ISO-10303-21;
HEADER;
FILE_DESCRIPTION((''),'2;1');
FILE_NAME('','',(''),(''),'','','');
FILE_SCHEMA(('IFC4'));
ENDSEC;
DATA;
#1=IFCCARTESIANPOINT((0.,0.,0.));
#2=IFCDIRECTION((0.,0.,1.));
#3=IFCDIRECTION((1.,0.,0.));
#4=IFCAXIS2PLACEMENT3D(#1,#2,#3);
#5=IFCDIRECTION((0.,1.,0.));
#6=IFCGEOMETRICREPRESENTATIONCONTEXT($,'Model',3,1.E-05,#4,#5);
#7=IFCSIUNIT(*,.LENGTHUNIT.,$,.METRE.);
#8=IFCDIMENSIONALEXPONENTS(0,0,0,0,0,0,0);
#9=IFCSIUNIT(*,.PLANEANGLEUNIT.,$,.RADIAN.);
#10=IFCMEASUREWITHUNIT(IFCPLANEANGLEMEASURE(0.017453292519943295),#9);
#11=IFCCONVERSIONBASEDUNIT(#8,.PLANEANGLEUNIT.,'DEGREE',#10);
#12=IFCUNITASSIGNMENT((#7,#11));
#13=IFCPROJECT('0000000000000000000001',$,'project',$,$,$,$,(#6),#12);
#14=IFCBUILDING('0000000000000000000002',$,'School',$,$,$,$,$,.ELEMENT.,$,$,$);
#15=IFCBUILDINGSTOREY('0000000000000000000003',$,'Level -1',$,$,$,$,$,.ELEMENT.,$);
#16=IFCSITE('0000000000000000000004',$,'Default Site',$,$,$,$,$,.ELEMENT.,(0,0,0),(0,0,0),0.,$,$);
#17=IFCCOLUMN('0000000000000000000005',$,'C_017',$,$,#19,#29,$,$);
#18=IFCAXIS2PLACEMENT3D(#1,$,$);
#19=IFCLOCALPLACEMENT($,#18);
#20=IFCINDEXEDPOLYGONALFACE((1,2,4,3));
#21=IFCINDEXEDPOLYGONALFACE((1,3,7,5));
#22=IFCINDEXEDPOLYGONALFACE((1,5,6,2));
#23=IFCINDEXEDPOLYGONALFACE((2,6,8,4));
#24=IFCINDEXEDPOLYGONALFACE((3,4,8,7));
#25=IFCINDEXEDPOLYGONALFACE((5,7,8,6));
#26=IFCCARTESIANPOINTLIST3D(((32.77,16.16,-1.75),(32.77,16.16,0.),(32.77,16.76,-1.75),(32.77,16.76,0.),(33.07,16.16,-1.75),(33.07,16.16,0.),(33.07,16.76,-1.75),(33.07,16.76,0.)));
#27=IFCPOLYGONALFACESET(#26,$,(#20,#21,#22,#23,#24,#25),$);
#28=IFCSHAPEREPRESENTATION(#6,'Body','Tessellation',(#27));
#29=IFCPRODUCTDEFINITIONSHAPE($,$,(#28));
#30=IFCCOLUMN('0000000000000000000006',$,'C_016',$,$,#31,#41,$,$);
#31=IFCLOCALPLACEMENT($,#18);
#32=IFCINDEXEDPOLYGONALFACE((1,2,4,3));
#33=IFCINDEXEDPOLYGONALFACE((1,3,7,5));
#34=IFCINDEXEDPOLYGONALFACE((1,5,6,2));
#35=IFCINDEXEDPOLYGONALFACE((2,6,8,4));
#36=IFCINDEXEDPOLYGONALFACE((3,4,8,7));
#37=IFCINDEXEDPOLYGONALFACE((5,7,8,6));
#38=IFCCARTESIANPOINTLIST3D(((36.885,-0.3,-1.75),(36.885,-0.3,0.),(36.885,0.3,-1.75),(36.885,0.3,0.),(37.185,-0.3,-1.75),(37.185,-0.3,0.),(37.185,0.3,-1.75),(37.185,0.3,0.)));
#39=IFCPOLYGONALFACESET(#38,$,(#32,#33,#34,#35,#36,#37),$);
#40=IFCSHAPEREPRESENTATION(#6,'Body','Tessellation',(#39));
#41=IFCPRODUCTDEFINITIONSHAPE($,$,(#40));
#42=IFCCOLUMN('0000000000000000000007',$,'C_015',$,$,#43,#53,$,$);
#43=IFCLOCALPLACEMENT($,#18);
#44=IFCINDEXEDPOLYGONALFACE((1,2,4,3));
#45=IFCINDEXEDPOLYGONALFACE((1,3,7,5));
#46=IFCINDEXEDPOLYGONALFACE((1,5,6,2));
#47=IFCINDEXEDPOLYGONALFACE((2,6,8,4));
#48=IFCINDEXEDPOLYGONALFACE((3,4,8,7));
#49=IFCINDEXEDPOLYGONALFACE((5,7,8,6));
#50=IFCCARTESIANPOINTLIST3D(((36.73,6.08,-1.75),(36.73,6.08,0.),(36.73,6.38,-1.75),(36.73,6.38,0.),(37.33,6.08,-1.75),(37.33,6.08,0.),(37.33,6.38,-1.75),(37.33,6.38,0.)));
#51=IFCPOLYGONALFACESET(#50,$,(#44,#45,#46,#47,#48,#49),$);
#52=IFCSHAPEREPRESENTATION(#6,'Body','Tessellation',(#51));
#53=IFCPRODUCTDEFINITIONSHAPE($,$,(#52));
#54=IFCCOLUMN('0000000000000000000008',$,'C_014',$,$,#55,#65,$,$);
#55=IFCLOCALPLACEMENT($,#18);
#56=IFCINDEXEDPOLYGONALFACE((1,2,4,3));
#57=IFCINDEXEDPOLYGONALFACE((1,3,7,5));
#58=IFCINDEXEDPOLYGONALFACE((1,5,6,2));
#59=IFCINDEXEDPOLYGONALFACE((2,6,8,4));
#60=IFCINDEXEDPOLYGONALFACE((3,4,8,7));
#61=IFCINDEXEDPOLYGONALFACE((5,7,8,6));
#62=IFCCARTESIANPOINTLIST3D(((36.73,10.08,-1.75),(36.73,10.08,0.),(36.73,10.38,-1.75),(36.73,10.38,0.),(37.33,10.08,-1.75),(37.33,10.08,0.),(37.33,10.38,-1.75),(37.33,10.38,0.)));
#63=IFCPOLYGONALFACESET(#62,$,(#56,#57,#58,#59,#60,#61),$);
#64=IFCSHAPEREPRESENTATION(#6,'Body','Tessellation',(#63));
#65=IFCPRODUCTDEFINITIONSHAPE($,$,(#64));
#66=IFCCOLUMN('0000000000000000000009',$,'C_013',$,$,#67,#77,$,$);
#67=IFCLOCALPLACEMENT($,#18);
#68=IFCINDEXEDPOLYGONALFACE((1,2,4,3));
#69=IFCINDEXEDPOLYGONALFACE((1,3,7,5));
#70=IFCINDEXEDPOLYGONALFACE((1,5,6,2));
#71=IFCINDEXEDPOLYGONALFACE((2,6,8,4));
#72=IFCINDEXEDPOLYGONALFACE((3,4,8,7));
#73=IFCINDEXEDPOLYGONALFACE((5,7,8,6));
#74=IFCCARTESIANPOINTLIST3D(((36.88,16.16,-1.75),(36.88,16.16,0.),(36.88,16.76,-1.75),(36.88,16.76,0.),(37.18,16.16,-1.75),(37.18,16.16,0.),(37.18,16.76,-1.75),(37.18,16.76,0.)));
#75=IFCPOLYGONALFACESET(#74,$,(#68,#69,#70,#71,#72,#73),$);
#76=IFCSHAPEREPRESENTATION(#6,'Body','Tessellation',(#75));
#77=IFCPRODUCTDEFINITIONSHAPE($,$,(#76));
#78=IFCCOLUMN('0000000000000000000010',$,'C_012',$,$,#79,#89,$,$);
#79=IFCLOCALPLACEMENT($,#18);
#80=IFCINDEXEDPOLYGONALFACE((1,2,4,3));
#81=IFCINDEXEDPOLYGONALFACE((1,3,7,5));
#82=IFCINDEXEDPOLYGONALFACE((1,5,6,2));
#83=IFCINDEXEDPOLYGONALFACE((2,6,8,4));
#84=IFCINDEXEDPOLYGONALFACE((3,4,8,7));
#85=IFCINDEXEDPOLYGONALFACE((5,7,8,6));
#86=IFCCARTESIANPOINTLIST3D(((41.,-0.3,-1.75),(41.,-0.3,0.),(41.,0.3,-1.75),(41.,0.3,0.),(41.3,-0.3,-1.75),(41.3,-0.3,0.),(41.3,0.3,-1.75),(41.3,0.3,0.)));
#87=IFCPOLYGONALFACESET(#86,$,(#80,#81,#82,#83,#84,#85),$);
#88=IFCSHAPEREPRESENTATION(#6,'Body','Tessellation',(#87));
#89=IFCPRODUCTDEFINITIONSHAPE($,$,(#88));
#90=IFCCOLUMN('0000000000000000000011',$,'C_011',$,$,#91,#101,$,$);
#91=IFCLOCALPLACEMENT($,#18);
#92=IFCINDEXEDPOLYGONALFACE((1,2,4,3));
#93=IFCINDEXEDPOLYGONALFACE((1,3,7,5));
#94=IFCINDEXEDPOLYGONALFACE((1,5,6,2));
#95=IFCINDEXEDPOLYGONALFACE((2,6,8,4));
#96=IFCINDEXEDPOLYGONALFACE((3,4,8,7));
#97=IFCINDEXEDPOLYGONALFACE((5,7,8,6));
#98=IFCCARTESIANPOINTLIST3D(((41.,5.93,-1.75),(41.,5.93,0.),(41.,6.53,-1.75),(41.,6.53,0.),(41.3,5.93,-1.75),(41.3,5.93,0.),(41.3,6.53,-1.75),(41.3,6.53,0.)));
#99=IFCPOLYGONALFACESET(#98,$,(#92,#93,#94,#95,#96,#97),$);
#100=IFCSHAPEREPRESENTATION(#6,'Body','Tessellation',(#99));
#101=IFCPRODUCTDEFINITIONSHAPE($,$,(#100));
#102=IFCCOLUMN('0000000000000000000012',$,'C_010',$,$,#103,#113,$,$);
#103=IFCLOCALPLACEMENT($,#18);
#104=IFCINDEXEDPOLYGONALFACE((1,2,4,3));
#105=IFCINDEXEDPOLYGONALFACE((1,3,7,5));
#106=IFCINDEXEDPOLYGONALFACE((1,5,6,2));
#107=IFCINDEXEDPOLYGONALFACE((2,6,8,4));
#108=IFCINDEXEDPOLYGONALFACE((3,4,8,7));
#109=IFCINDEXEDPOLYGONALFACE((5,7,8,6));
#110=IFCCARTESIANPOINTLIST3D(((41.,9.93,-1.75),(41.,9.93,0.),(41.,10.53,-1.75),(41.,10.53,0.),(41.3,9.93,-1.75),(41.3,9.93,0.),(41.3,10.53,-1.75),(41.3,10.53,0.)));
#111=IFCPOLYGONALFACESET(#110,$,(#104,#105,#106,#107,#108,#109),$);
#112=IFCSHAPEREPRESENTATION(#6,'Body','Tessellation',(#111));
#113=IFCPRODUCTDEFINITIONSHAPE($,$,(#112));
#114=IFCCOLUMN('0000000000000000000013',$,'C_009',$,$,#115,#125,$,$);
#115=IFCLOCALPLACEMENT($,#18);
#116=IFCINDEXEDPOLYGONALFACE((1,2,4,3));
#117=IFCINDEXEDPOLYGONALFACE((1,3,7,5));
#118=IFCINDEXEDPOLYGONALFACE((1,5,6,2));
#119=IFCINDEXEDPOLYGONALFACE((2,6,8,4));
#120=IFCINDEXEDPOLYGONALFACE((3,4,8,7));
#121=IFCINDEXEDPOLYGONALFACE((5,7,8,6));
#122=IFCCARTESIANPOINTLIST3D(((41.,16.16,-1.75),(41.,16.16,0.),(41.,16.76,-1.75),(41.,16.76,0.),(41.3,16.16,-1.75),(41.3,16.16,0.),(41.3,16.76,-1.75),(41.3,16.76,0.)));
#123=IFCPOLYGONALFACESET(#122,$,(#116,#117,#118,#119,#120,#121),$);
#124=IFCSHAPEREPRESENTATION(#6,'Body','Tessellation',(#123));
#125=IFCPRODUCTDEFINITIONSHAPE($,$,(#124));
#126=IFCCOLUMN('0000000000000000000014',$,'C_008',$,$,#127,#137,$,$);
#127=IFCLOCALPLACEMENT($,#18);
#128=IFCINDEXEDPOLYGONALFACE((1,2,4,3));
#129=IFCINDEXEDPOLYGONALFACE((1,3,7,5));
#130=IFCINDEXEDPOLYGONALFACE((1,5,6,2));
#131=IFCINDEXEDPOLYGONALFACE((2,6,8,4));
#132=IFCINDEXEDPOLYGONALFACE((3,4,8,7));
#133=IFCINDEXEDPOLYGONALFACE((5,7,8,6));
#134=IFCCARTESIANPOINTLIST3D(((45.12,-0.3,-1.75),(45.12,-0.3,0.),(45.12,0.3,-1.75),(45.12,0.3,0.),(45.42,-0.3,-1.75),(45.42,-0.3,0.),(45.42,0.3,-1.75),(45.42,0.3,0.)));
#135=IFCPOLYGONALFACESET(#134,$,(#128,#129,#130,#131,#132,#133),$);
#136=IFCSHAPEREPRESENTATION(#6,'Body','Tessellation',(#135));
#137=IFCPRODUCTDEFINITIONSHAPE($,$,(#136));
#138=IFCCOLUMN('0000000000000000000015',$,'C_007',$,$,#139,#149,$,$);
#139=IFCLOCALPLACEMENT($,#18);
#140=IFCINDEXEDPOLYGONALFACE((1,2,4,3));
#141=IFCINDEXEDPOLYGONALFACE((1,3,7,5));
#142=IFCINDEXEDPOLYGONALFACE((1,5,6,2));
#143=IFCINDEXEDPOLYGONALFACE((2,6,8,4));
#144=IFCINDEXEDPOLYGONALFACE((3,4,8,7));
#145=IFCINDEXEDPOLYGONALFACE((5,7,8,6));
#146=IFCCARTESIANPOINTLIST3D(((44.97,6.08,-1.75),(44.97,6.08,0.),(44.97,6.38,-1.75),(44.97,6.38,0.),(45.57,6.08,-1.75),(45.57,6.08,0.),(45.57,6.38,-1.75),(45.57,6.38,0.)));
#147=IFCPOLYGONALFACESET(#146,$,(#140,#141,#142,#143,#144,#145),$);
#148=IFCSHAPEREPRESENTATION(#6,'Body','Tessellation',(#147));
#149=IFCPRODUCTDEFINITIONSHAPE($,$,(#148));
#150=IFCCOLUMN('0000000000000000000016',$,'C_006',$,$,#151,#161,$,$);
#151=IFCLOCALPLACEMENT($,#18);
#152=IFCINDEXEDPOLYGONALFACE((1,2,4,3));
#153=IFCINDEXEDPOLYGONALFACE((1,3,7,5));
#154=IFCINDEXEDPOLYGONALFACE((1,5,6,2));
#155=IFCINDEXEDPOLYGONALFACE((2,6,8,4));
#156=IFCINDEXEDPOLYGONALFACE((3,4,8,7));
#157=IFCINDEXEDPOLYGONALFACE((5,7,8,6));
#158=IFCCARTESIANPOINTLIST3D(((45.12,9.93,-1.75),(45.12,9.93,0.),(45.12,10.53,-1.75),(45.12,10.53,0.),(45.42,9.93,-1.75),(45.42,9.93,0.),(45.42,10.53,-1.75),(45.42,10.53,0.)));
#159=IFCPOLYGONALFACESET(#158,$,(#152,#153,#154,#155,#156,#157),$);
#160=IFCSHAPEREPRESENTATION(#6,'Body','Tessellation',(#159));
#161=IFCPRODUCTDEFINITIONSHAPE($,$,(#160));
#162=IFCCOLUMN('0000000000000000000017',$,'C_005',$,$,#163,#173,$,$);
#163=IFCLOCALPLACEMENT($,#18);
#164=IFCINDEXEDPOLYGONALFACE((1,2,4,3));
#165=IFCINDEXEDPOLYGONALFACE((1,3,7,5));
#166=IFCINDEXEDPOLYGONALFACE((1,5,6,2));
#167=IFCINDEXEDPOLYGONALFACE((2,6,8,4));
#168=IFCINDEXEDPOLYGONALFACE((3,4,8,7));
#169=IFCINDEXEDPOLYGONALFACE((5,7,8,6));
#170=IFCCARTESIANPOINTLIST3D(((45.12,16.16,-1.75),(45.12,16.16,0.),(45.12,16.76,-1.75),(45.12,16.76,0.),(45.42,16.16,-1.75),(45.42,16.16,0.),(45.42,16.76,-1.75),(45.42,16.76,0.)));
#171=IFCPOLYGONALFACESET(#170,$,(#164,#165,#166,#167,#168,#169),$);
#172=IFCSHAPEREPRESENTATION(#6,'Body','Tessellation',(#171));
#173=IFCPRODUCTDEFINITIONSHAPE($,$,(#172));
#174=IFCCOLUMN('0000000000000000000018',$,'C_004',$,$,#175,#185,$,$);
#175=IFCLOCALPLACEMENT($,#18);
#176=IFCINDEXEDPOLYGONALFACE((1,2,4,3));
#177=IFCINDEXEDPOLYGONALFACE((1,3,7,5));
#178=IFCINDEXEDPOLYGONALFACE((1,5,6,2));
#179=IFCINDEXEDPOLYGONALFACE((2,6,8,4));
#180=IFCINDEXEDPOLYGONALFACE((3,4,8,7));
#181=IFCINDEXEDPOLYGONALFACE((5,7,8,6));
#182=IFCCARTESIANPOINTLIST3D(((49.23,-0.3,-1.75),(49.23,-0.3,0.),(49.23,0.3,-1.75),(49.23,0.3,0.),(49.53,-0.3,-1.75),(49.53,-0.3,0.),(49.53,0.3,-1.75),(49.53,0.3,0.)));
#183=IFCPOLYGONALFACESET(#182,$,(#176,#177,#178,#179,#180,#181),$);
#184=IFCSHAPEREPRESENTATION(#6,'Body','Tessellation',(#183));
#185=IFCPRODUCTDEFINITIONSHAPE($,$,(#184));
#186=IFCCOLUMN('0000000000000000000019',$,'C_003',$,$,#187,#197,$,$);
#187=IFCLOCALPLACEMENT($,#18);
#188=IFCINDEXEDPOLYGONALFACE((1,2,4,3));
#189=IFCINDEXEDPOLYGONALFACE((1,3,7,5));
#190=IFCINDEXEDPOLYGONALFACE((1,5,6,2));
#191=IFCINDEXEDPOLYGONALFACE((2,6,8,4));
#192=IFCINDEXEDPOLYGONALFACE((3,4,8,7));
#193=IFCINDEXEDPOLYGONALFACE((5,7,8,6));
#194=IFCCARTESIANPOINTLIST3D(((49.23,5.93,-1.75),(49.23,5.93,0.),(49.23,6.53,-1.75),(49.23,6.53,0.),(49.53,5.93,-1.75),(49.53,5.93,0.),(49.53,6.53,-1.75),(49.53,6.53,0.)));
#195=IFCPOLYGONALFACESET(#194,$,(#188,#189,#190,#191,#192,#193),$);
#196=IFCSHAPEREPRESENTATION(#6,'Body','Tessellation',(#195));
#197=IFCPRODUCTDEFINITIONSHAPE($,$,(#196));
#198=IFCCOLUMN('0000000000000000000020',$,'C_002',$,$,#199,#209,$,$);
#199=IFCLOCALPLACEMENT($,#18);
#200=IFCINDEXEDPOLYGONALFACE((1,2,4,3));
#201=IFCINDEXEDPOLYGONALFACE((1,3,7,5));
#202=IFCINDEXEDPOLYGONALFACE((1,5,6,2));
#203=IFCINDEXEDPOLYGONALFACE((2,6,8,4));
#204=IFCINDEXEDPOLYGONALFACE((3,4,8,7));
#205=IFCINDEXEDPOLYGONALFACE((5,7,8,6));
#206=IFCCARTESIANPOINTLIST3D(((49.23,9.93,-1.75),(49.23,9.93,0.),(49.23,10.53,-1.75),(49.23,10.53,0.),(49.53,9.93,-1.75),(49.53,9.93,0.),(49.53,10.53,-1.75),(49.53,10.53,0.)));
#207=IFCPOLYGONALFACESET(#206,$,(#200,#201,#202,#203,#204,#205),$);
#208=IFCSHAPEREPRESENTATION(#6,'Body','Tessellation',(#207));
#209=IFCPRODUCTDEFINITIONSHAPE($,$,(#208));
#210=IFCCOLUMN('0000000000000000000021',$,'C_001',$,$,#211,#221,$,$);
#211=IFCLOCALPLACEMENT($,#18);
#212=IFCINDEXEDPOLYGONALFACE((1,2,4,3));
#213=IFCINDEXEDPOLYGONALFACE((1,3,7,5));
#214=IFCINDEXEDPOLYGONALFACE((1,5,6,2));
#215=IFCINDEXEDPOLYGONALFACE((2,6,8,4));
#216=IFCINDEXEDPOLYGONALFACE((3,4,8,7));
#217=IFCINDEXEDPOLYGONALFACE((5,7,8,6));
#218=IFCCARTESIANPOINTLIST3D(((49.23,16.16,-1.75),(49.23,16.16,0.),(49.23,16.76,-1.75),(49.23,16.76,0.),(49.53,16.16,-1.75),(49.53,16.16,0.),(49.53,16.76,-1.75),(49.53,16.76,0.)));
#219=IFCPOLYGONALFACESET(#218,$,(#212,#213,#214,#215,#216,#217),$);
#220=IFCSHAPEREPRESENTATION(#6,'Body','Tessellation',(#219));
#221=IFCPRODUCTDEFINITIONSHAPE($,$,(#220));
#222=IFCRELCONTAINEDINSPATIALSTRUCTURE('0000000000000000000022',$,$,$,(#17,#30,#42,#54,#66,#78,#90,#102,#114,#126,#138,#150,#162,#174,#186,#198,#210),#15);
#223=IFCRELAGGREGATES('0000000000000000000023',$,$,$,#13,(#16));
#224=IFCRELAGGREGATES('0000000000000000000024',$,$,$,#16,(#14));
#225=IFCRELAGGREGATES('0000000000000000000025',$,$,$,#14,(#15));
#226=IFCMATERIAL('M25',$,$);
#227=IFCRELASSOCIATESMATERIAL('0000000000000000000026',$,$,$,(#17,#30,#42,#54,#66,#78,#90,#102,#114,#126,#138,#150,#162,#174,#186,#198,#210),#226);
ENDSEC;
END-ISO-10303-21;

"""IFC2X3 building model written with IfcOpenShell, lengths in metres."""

from ifc_helpers import new_model, entity, si_unit, converted_unit, direction, frame, frame_2d, origin_with_axes, place, context, project, spatial, rectangle, extrude, material, element, save


model = new_model("IFC2X3")

# Units and contexts
model_context = context("Model", 3, precision=1e-05, world=origin_with_axes(), true_north=direction((0.0, 1.0, 0.0)))
ifc_project = project(units=[si_unit("LENGTHUNIT", "METRE"), converted_unit("PLANEANGLEUNIT", "DEGREE", entity("IfcPlaneAngleMeasure", 0.017453292519943295), si_unit("PLANEANGLEUNIT", "RADIAN"), dimensions=[0, 0, 0, 0, 0, 0, 0])], contexts=[model_context])

# Site, building, storey
site = spatial("IfcSite", under=ifc_project, Name="Default Site", CompositionType="ELEMENT", RefLatitude=(0, 0, 0), RefLongitude=(0, 0, 0), RefElevation=0.0)
building = spatial("IfcBuilding", under=site, Name="School", CompositionType="ELEMENT")
storey = spatial("IfcBuildingStorey", under=building, Name="Level -1", CompositionType="ELEMENT")

# Columns
ifc_material = material(Name="M25")
placement = place(None, origin_with_axes())
element("IfcColumn", 1, at=placement, inside=storey, material=ifc_material, Name="C_017", context=model_context, shape_type="SweptSolid", body=[
    extrude(rectangle(XDim=0.3, YDim=0.6, at=frame_2d((0.0, 0.0), x_axis=(1.0, 0.0, 0.0))), frame((32.92, 16.46, -1.75), z_axis=(0.0, 0.0, 1.0), x_axis=(1.0, 0.0, 0.0)), (0.0, 0.0, 1.0), 1.75),
])
element("IfcColumn", 2, at=placement, inside=storey, material=ifc_material, Name="C_016", context=model_context, shape_type="SweptSolid", body=[
    extrude(rectangle(XDim=0.3, YDim=0.6, at=frame_2d((0.0, 0.0), x_axis=(1.0, 0.0, 0.0))), frame((37.035, 0.0, -1.75), z_axis=(0.0, 0.0, 1.0), x_axis=(1.0, 0.0, 0.0)), (0.0, 0.0, 1.0), 1.75),
])
element("IfcColumn", 3, at=placement, inside=storey, material=ifc_material, Name="C_015", context=model_context, shape_type="SweptSolid", body=[
    extrude(rectangle(XDim=0.6, YDim=0.3, at=frame_2d((0.0, 0.0), x_axis=(1.0, 0.0, 0.0))), frame((37.03, 6.23, -1.75), z_axis=(0.0, 0.0, 1.0), x_axis=(1.0, 0.0, 0.0)), (0.0, 0.0, 1.0), 1.75),
])
element("IfcColumn", 4, at=placement, inside=storey, material=ifc_material, Name="C_014", context=model_context, shape_type="SweptSolid", body=[
    extrude(rectangle(XDim=0.6, YDim=0.3, at=frame_2d((0.0, 0.0), x_axis=(1.0, 0.0, 0.0))), frame((37.03, 10.23, -1.75), z_axis=(0.0, 0.0, 1.0), x_axis=(1.0, 0.0, 0.0)), (0.0, 0.0, 1.0), 1.75),
])
element("IfcColumn", 5, at=placement, inside=storey, material=ifc_material, Name="C_013", context=model_context, shape_type="SweptSolid", body=[
    extrude(rectangle(XDim=0.3, YDim=0.6, at=frame_2d((0.0, 0.0), x_axis=(1.0, 0.0, 0.0))), frame((37.03, 16.46, -1.75), z_axis=(0.0, 0.0, 1.0), x_axis=(1.0, 0.0, 0.0)), (0.0, 0.0, 1.0), 1.75),
])
element("IfcColumn", 6, at=placement, inside=storey, material=ifc_material, Name="C_012", context=model_context, shape_type="SweptSolid", body=[
    extrude(rectangle(XDim=0.3, YDim=0.6, at=frame_2d((0.0, 0.0), x_axis=(1.0, 0.0, 0.0))), frame((41.15, 0.0, -1.75), z_axis=(0.0, 0.0, 1.0), x_axis=(1.0, 0.0, 0.0)), (0.0, 0.0, 1.0), 1.75),
])
element("IfcColumn", 7, at=placement, inside=storey, material=ifc_material, Name="C_011", context=model_context, shape_type="SweptSolid", body=[
    extrude(rectangle(XDim=0.3, YDim=0.6, at=frame_2d((0.0, 0.0), x_axis=(1.0, 0.0, 0.0))), frame((41.15, 6.23, -1.75), z_axis=(0.0, 0.0, 1.0), x_axis=(1.0, 0.0, 0.0)), (0.0, 0.0, 1.0), 1.75),
])
element("IfcColumn", 8, at=placement, inside=storey, material=ifc_material, Name="C_010", context=model_context, shape_type="SweptSolid", body=[
    extrude(rectangle(XDim=0.3, YDim=0.6, at=frame_2d((0.0, 0.0), x_axis=(1.0, 0.0, 0.0))), frame((41.15, 10.23, -1.75), z_axis=(0.0, 0.0, 1.0), x_axis=(1.0, 0.0, 0.0)), (0.0, 0.0, 1.0), 1.75),
])
element("IfcColumn", 9, at=placement, inside=storey, material=ifc_material, Name="C_009", context=model_context, shape_type="SweptSolid", body=[
    extrude(rectangle(XDim=0.3, YDim=0.6, at=frame_2d((0.0, 0.0), x_axis=(1.0, 0.0, 0.0))), frame((41.15, 16.46, -1.75), z_axis=(0.0, 0.0, 1.0), x_axis=(1.0, 0.0, 0.0)), (0.0, 0.0, 1.0), 1.75),
])
element("IfcColumn", 10, at=placement, inside=storey, material=ifc_material, Name="C_008", context=model_context, shape_type="SweptSolid", body=[
    extrude(rectangle(XDim=0.3, YDim=0.6, at=frame_2d((0.0, 0.0), x_axis=(1.0, 0.0, 0.0))), frame((45.27, 0.0, -1.75), z_axis=(0.0, 0.0, 1.0), x_axis=(1.0, 0.0, 0.0)), (0.0, 0.0, 1.0), 1.75),
])
element("IfcColumn", 11, at=placement, inside=storey, material=ifc_material, Name="C_007", context=model_context, shape_type="SweptSolid", body=[
    extrude(rectangle(XDim=0.6, YDim=0.3, at=frame_2d((0.0, 0.0), x_axis=(1.0, 0.0, 0.0))), frame((45.27, 6.23, -1.75), z_axis=(0.0, 0.0, 1.0), x_axis=(1.0, 0.0, 0.0)), (0.0, 0.0, 1.0), 1.75),
])
element("IfcColumn", 12, at=placement, inside=storey, material=ifc_material, Name="C_006", context=model_context, shape_type="SweptSolid", body=[
    extrude(rectangle(XDim=0.3, YDim=0.6, at=frame_2d((0.0, 0.0), x_axis=(1.0, 0.0, 0.0))), frame((45.27, 10.23, -1.75), z_axis=(0.0, 0.0, 1.0), x_axis=(1.0, 0.0, 0.0)), (0.0, 0.0, 1.0), 1.75),
])
element("IfcColumn", 13, at=placement, inside=storey, material=ifc_material, Name="C_005", context=model_context, shape_type="SweptSolid", body=[
    extrude(rectangle(XDim=0.3, YDim=0.6, at=frame_2d((0.0, 0.0), x_axis=(1.0, 0.0, 0.0))), frame((45.27, 16.46, -1.75), z_axis=(0.0, 0.0, 1.0), x_axis=(1.0, 0.0, 0.0)), (0.0, 0.0, 1.0), 1.75),
])
element("IfcColumn", 14, at=placement, inside=storey, material=ifc_material, Name="C_004", context=model_context, shape_type="SweptSolid", body=[
    extrude(rectangle(XDim=0.3, YDim=0.6, at=frame_2d((0.0, 0.0), x_axis=(1.0, 0.0, 0.0))), frame((49.38, 0.0, -1.75), z_axis=(0.0, 0.0, 1.0), x_axis=(1.0, 0.0, 0.0)), (0.0, 0.0, 1.0), 1.75),
])
element("IfcColumn", 15, at=placement, inside=storey, material=ifc_material, Name="C_003", context=model_context, shape_type="SweptSolid", body=[
    extrude(rectangle(XDim=0.3, YDim=0.6, at=frame_2d((0.0, 0.0), x_axis=(1.0, 0.0, 0.0))), frame((49.38, 6.23, -1.75), z_axis=(0.0, 0.0, 1.0), x_axis=(1.0, 0.0, 0.0)), (0.0, 0.0, 1.0), 1.75),
])
element("IfcColumn", 16, at=placement, inside=storey, material=ifc_material, Name="C_002", context=model_context, shape_type="SweptSolid", body=[
    extrude(rectangle(XDim=0.3, YDim=0.6, at=frame_2d((0.0, 0.0), x_axis=(1.0, 0.0, 0.0))), frame((49.38, 10.23, -1.75), z_axis=(0.0, 0.0, 1.0), x_axis=(1.0, 0.0, 0.0)), (0.0, 0.0, 1.0), 1.75),
])
element("IfcColumn", 17, at=placement, inside=storey, material=ifc_material, Name="C_001", context=model_context, shape_type="SweptSolid", body=[
    extrude(rectangle(XDim=0.3, YDim=0.6, at=frame_2d((0.0, 0.0), x_axis=(1.0, 0.0, 0.0))), frame((49.38, 16.46, -1.75), z_axis=(0.0, 0.0, 1.0), x_axis=(1.0, 0.0, 0.0)), (0.0, 0.0, 1.0), 1.75),
])

save(model, "model.ifc")
